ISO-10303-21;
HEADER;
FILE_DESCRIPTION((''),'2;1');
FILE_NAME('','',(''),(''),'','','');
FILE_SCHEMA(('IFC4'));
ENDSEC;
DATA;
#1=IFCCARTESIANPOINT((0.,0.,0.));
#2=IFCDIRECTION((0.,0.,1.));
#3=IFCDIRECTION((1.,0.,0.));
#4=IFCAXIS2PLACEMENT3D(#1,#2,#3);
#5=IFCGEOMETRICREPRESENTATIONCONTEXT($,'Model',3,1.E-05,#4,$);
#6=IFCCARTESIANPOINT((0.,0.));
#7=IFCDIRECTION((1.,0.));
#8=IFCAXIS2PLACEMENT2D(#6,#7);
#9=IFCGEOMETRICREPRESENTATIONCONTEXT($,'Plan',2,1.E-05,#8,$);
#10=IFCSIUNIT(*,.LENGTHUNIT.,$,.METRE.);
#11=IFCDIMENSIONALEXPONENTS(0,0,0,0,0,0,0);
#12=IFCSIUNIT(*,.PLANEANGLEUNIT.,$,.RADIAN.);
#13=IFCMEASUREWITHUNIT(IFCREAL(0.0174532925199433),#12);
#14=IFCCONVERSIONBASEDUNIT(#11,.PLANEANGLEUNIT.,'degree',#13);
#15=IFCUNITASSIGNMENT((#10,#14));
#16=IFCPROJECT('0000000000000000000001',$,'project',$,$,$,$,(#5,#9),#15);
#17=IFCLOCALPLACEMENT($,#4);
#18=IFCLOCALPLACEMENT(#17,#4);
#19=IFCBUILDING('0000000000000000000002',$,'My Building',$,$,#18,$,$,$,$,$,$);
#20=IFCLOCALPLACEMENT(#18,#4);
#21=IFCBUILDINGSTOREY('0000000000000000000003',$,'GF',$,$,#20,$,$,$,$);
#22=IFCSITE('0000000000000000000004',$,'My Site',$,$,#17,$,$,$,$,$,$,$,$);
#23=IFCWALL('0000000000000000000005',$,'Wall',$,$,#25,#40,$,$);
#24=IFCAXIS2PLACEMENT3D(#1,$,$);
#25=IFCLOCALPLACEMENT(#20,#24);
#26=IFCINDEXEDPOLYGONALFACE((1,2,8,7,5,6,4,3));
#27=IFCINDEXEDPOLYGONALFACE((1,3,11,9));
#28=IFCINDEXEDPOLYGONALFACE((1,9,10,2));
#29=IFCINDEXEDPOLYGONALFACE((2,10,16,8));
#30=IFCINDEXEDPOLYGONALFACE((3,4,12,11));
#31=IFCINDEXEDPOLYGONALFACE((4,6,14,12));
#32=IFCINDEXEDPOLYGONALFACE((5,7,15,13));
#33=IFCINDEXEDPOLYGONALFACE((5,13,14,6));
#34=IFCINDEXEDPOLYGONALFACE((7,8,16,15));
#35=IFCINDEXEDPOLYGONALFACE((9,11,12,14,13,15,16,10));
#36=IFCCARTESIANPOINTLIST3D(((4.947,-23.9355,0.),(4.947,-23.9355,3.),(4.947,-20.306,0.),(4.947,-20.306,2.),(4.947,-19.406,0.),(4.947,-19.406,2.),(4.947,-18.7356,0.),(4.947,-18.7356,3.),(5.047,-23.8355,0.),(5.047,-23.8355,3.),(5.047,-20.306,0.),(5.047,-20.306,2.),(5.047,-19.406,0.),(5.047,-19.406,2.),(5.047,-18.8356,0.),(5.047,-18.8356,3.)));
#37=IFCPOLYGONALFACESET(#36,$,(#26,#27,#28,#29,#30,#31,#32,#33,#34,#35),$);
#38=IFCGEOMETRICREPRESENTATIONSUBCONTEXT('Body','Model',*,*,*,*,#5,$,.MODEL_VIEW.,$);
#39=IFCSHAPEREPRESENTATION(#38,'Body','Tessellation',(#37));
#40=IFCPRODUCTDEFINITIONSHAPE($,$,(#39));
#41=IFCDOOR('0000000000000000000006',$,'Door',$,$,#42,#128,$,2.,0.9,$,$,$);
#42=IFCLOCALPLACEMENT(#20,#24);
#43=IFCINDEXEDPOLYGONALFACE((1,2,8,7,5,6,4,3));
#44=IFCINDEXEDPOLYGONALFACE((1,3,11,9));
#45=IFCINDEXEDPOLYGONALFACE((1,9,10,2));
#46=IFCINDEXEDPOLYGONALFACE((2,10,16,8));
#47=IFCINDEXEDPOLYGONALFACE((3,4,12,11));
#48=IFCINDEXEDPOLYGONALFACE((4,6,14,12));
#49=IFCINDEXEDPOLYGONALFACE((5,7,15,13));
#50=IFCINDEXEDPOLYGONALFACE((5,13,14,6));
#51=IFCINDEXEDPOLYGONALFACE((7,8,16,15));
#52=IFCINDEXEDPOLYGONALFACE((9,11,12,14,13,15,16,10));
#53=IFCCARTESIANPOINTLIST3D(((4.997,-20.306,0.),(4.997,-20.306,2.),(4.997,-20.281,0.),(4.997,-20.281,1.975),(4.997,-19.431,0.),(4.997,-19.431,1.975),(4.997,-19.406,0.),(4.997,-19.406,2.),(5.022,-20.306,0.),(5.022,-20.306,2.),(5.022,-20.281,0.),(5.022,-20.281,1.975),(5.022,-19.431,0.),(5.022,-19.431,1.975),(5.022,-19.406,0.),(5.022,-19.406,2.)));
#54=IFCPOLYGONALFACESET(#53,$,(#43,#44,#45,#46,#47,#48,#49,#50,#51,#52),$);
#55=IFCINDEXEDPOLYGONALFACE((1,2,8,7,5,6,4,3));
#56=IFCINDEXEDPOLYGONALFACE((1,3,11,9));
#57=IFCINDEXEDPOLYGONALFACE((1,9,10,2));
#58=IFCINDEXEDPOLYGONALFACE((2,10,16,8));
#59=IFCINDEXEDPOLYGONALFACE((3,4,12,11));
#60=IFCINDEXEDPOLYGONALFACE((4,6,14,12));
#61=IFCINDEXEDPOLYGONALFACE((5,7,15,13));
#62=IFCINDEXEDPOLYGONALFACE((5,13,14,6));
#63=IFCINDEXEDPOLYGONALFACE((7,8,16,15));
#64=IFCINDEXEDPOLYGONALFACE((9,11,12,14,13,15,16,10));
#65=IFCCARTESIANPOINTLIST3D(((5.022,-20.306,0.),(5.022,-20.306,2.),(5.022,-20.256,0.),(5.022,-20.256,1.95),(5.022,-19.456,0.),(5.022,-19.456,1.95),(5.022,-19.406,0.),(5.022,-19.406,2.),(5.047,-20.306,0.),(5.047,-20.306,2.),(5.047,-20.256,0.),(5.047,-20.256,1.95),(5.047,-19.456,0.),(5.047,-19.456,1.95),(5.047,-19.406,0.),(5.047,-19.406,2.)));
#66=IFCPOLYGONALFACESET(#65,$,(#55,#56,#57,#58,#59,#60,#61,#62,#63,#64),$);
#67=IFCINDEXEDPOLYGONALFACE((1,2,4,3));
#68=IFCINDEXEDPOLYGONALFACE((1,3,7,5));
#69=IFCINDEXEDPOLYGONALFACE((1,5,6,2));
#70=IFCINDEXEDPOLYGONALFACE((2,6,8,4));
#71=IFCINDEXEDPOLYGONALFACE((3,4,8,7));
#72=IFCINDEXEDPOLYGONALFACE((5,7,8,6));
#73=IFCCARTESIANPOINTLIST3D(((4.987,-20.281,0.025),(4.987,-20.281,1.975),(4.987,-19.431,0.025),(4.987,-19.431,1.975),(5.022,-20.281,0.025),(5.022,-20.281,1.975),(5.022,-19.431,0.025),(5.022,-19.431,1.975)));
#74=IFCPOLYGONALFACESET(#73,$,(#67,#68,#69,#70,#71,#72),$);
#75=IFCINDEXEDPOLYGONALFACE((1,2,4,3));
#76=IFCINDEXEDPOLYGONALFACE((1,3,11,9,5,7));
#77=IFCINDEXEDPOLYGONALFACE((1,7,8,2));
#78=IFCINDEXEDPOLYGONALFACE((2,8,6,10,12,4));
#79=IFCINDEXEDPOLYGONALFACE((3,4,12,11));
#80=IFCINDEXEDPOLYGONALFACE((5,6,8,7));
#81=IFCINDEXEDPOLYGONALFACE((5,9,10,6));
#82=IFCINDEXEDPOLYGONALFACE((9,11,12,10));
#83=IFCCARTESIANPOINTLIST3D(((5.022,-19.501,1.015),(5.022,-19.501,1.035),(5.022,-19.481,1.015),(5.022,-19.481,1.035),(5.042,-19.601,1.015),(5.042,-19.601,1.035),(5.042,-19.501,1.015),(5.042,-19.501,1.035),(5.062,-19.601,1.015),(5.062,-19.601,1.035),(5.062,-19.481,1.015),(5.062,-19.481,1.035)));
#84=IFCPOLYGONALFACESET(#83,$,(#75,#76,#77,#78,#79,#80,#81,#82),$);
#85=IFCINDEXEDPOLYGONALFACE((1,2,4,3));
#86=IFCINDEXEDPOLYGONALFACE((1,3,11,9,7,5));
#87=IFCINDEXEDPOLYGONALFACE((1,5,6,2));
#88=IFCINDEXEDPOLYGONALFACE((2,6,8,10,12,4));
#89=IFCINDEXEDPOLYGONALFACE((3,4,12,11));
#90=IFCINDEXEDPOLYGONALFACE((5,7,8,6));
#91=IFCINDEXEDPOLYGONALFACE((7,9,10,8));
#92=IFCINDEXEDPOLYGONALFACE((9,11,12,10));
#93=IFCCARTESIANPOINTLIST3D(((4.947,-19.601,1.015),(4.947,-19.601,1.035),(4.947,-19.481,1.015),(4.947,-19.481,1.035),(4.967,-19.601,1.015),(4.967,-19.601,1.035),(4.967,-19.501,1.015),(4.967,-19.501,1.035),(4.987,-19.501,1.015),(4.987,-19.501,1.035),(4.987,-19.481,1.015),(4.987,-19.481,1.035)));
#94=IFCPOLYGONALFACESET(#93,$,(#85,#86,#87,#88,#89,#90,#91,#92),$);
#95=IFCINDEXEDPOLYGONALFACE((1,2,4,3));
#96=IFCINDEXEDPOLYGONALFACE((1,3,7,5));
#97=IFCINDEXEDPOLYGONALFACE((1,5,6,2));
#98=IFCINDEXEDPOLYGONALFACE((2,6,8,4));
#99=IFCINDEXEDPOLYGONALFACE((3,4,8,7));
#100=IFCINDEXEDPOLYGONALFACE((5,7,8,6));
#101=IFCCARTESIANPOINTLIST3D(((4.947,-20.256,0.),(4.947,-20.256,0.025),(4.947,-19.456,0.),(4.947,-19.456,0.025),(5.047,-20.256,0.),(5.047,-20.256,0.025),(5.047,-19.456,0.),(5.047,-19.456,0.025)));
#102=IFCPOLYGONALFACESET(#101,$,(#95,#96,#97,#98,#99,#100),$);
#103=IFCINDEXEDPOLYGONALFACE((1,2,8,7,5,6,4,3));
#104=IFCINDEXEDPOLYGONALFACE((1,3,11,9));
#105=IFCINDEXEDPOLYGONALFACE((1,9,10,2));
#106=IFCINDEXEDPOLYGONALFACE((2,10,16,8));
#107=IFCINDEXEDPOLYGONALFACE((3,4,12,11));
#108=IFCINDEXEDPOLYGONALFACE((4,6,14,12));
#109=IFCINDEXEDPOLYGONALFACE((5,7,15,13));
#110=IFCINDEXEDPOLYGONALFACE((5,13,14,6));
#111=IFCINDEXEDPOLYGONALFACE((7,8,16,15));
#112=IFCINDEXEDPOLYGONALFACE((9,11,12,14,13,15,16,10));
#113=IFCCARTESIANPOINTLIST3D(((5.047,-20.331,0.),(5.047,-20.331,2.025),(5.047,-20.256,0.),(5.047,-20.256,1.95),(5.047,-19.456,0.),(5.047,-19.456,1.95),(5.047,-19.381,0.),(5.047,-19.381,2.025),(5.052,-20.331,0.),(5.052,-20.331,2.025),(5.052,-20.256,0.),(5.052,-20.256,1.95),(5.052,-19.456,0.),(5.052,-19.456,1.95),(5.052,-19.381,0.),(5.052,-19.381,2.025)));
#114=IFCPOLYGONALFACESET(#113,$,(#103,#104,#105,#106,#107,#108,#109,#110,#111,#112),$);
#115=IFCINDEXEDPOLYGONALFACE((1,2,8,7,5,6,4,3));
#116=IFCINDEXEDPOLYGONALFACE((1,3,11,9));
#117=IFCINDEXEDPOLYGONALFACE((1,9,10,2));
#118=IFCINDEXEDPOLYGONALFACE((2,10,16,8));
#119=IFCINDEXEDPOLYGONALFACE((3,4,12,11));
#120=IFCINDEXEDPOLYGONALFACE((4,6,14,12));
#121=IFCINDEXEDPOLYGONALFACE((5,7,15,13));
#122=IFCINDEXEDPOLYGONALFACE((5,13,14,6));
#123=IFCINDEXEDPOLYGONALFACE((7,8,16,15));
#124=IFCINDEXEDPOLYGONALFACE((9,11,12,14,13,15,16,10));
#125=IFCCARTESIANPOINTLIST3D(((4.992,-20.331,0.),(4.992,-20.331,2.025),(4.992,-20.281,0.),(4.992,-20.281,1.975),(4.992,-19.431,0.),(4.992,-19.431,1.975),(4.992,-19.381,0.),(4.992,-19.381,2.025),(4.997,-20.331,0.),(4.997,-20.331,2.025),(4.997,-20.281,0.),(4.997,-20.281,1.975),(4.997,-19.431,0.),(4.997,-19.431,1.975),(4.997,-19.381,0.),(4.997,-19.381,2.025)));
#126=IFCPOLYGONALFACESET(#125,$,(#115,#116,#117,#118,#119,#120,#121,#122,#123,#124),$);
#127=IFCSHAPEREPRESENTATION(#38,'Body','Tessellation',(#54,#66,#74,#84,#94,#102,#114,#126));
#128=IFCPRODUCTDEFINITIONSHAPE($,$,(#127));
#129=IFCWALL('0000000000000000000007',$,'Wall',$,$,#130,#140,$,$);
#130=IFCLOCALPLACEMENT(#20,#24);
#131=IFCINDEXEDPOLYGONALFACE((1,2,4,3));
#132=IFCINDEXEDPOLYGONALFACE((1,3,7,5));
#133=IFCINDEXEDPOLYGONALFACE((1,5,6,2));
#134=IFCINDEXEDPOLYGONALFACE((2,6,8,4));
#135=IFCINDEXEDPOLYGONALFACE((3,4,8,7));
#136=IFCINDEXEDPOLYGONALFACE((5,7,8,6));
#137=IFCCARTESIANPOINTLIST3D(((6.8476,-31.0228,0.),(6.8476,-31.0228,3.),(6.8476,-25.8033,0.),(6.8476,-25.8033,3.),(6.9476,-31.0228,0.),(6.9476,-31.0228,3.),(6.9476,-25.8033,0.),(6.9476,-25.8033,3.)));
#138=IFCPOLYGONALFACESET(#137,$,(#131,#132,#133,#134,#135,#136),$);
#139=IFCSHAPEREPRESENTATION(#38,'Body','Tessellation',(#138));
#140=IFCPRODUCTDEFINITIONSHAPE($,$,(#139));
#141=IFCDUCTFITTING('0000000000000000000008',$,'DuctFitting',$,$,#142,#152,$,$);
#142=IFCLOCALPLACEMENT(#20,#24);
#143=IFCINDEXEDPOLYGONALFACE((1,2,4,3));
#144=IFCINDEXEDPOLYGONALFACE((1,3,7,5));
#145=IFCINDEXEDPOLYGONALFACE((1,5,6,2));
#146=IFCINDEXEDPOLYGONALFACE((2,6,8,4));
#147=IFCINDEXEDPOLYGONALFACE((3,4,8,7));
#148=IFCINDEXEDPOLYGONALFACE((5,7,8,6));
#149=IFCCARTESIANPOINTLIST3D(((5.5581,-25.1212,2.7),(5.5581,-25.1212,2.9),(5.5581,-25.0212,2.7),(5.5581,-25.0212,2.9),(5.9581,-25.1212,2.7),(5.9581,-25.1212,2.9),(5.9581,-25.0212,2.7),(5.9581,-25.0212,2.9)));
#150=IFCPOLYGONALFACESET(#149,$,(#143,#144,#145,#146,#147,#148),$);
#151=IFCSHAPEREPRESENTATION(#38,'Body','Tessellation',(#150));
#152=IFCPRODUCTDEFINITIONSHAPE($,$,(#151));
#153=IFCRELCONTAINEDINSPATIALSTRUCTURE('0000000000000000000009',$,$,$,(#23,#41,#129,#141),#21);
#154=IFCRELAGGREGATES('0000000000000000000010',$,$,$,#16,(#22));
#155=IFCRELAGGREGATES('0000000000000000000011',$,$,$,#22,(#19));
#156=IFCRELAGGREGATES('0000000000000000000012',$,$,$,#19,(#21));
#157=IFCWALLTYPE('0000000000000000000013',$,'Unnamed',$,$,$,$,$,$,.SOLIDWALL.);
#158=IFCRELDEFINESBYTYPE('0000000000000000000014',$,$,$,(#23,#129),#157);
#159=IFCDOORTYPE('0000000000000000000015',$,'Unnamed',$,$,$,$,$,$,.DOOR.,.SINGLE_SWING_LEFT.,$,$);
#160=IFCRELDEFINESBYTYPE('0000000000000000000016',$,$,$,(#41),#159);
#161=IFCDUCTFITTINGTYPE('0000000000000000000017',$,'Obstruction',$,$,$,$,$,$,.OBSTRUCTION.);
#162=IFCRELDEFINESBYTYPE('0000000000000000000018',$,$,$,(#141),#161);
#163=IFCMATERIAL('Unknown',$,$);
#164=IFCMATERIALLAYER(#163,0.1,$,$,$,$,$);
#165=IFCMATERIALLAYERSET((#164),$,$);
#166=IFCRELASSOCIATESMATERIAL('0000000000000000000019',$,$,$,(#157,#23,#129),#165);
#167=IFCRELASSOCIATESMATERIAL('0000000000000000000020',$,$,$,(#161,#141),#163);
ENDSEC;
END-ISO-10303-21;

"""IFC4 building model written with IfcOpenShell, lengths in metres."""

from ifc_helpers import new_model, entity, si_unit, converted_unit, frame, origin_with_axes, origin_2d_with_axis, place, context, subcontext, project, spatial, line, indexed_curve, rectangle, outline, extrude, shape, source, transform, mapped, material, layer, layer_set, layer_usage, material_profile, profile_set, profile_usage, type_object, type_shapes, element, fill, save


model = new_model("IFC4")

# Units and contexts
model_context = context("Model", 3, precision=1e-05, world=origin_with_axes())
plan_context = context("Plan", 2, precision=1e-05, world=origin_2d_with_axis())
body_context_1 = subcontext(model_context, "Body", "Model", "MODEL_VIEW")
body_context_2 = subcontext(plan_context, "Body", "Plan", "PLAN_VIEW")
ifc_project = project(units=[si_unit("LENGTHUNIT", "METRE"), converted_unit("PLANEANGLEUNIT", "degree", entity("IfcReal", 0.0174532925199433), si_unit("PLANEANGLEUNIT", "RADIAN"), dimensions=[0, 0, 0, 0, 0, 0, 0])], contexts=[model_context, plan_context])

# Site, building, storey
site_placement = place(None, origin_with_axes())
site = spatial("IfcSite", under=ifc_project, at=site_placement, Name="My Site")
building_placement = place(site_placement, origin_with_axes())
building = spatial("IfcBuilding", under=site, at=building_placement, Name="My Building")
storey_placement = place(building_placement, origin_with_axes())
storey = spatial("IfcBuildingStorey", under=building, at=storey_placement, Name="GF")

# Shared definitions
ifc_material = material(Name="Unknown")

# Shared definitions
ifc_layer_1 = layer(ifc_material, 0.1)
ifc_layer_set_1 = layer_set([ifc_layer_1])
wall_type = type_object("IfcWallType", Name="Unnamed", PredefinedType="SOLIDWALL", material=ifc_layer_set_1)

# Shared definitions
shared_shape_1 = source(origin_with_axes(), body_context_1, "Body", "SweptSolid", [
    extrude(outline(indexed_curve([(0.0, 0.0), (0.9, 0.0), (0.9, 2.0), (0.0, 2.0)], segments=[line(1, 2, 3, 4, 1)])), frame((0.0, -0.6, 0.0), z_axis=(0.0, -1.0, 0.0), x_axis=(1.0, 0.0, 0.0)), (0.0, 0.0, -1.0), 1.2),
])
door_type = type_object("IfcDoorType", Name="Unnamed", OperationType="SINGLE_SWING_LEFT", PredefinedType="DOOR")
shared_shape_2 = source(origin_with_axes(), body_context_1, "Body", "SweptSolid", [
    extrude(outline(indexed_curve([(0.0, 0.0), (0.0, 2.0), (0.9, 2.0), (0.9, 0.0), (0.875, 0.0), (0.875, 1.975), (0.025, 1.975), (0.025, 0.0)], segments=[line(1, 2, 3, 4, 5, 6, 7, 8, 1)])), frame((0.0, 0.025, 0.0), z_axis=(0.0, -1.0, 0.0), x_axis=(1.0, 0.0, 0.0)), (0.0, 0.0, -1.0), 0.025),
    extrude(outline(indexed_curve([(0.0, 0.0), (0.0, 2.0), (0.9, 2.0), (0.9, 0.0), (0.85, 0.0), (0.85, 1.95), (0.05, 1.95), (0.05, 0.0)], segments=[line(1, 2, 3, 4, 5, 6, 7, 8, 1)])), frame((0.0, 0.0, 0.0), z_axis=(0.0, -1.0, 0.0), x_axis=(1.0, 0.0, 0.0)), (0.0, 0.0, -1.0), 0.025),
    extrude(outline(indexed_curve([(0.0, 0.0), (0.85, 0.0), (0.85, 0.035), (0.0, 0.035)], segments=[line(1, 2, 3, 4, 1)])), frame((0.025, 0.025, 0.025), z_axis=(0.0, 0.0, 1.0), x_axis=(1.0, 0.0, 0.0)), (0.0, 0.0, 1.0), 1.95),
    extrude(outline(indexed_curve([(0.0, 0.0), (0.0, -0.04), (-0.12, -0.04), (-0.12, -0.02), (-0.02, -0.02), (-0.02, 0.0)], segments=[line(1, 2, 3, 4, 5, 6, 1)])), frame((0.825, 0.025, 1.015), z_axis=(0.0, 0.0, 1.0), x_axis=(1.0, 0.0, 0.0)), (0.0, 0.0, 1.0), 0.02),
    extrude(outline(indexed_curve([(0.0, 0.0), (0.0, 0.04), (-0.12, 0.04), (-0.12, 0.02), (-0.02, 0.02), (-0.02, 0.0)], segments=[line(1, 2, 3, 4, 5, 6, 1)])), frame((0.825, 0.06, 1.015), z_axis=(0.0, 0.0, 1.0), x_axis=(1.0, 0.0, 0.0)), (0.0, 0.0, 1.0), 0.02),
    extrude(outline(indexed_curve([(0.0, 0.0), (0.8, 0.0), (0.8, 0.1), (0.0, 0.1)], segments=[line(1, 2, 3, 4, 1)])), frame((0.05, 0.0, 0.0), z_axis=(0.0, 0.0, 1.0), x_axis=(1.0, 0.0, 0.0)), (0.0, 0.0, 1.0), 0.025),
    extrude(outline(indexed_curve([(0.0, 0.0), (0.0, 2.025), (0.95, 2.025), (0.95, 0.0), (0.875, 0.0), (0.875, 1.95), (0.075, 1.95), (0.075, 0.0)], segments=[line(1, 2, 3, 4, 5, 6, 7, 8, 1)])), frame((-0.025, -0.005, 0.0), z_axis=(0.0, -1.0, 0.0), x_axis=(1.0, 0.0, 0.0)), (0.0, 0.0, -1.0), 0.005),
    extrude(outline(indexed_curve([(0.0, 0.0), (0.0, 2.025), (0.95, 2.025), (0.95, 0.0), (0.9, 0.0), (0.9, 1.975), (0.05, 1.975), (0.05, 0.0)], segments=[line(1, 2, 3, 4, 5, 6, 7, 8, 1)])), frame((-0.025, 0.05, 0.0), z_axis=(0.0, -1.0, 0.0), x_axis=(1.0, 0.0, 0.0)), (0.0, 0.0, -1.0), 0.005),
])
shared_shape_3 = source(origin_with_axes(), body_context_2, "Body", "Curve2D", [
    entity("IfcIndexedPolyCurve", entity("IfcCartesianPointList2D", [[0.0, 0.0], [0.0, 0.05], [0.025, 0.05], [0.025, 0.025], [0.05, 0.025], [0.05, 0.0]]), [entity("IfcLineIndex", [1, 2, 3, 4, 5, 6, 1])]),
    entity("IfcIndexedPolyCurve", entity("IfcCartesianPointList2D", [[0.9, 0.0], [0.9, 0.05], [0.875, 0.05], [0.875, 0.025], [0.85, 0.025], [0.85, 0.0]]), [entity("IfcLineIndex", [1, 2, 3, 4, 5, 6, 1])]),
    entity("IfcTrimmedCurve", entity("IfcEllipse", entity("IfcAxis2Placement2D", entity("IfcCartesianPoint", [0.06, 0.05]), entity("IfcDirection", [1.0, 0.0])), 0.815, 0.85), [entity("IfcCartesianPoint", [0.875, 0.05])], [entity("IfcCartesianPoint", [0.06, 0.9])], True, "CARTESIAN"),
    entity("IfcIndexedPolyCurve", entity("IfcCartesianPointList2D", [[0.025, 0.05], [0.06, 0.05], [0.06, 0.9], [0.025, 0.9]]), [entity("IfcLineIndex", [1, 2, 3, 4, 1])]),
])
type_shapes(door_type, [shared_shape_2, shared_shape_3])

# Wall, opening, door
ifc_layer_usage_1 = layer_usage(ifc_layer_set_1, "AXIS2", "POSITIVE", 0.0)
wall_1_placement = place(storey_placement, frame((5.047, -23.8355, 0.0), z_axis=(0.0, 0.0, 1.0), x_axis=(0.0, 1.0, 0.0)))
wall_1 = element("IfcWall", 1, at=wall_1_placement, inside=storey, type_object=wall_type, material=ifc_layer_usage_1, Name="Wall", context=body_context_1, shape_type="SweptSolid", body=[
    extrude(outline(indexed_curve([(0.0, 0.0), (-0.1, 0.1), (5.1, 0.1), (5.0, 0.0)], segments=[line(1, 2, 3, 4, 1)])), origin_with_axes(), (0.0, 0.0, 1.0), 3.0),
])
opening_1_placement = place(wall_1_placement, frame((3.5295, 0.0, 0.0), z_axis=(0.0, 0.0, 1.0), x_axis=(1.0, 0.0, 0.0)))
opening_1 = element("IfcOpeningElement", 2, at=opening_1_placement, cuts=wall_1, PredefinedType="OPENING", context=body_context_1, shape_type="MappedRepresentation", body=[
    mapped(shared_shape_1, transform((0.0, 0.0, 0.0), x_axis=(1.0, 0.0, 0.0), y_axis=(0.0, 1.0, 0.0), z_axis=(0.0, 0.0, 1.0), scale=1.0)),
])
door_1_placement = place(opening_1_placement, frame((0.0, 0.0, 0.0), z_axis=(0.0, 0.0, 1.0), x_axis=(1.0, 0.0, 0.0)))
door_1 = element("IfcDoor", 3, at=door_1_placement, inside=storey, type_object=door_type, Name="Door", OverallHeight=2.0, OverallWidth=0.9, shapes=[
    shape(body_context_1, "Body", "MappedRepresentation", [mapped(shared_shape_2, transform((0.0, 0.0, 0.0), x_axis=(1.0, 0.0, 0.0), y_axis=(0.0, 1.0, 0.0), z_axis=(0.0, 0.0, 1.0), scale=1.0))]),
    shape(body_context_2, "Body", "MappedRepresentation", [mapped(shared_shape_3, transform((0.0, 0.0, 0.0), x_axis=(1.0, 0.0, 0.0), y_axis=(0.0, 1.0, 0.0), z_axis=(0.0, 0.0, 1.0), scale=1.0))]),
])
fill(opening_1, door_1)

# Wall
ifc_layer_usage_2 = layer_usage(ifc_layer_set_1, "AXIS2", "POSITIVE", 0.0)
wall_2_placement = place(storey_placement, frame((6.8476, -25.8033, 0.0), z_axis=(0.0, 0.0, 1.0), x_axis=(0.0, -1.0, 0.0)))
element("IfcWall", 4, at=wall_2_placement, inside=storey, type_object=wall_type, material=ifc_layer_usage_2, Name="Wall", context=body_context_1, shape_type="SweptSolid", body=[
    extrude(outline(indexed_curve([(0.0, 0.0), (0.0, 0.1), (5.2195, 0.1), (5.2195, 0.0)], segments=[line(1, 2, 3, 4, 1)])), origin_with_axes(), (0.0, 0.0, 1.0), 3.0),
])

# Duct fitting
ifc_material_profile = material_profile(ifc_material, rectangle(XDim=0.4, YDim=0.2))
ifc_profile_set = profile_set([ifc_material_profile])
ifc_profile_usage = profile_usage(ifc_profile_set, cardinal=5)
duct_fitting_type = type_object("IfcDuctFittingType", Name="Obstruction", PredefinedType="OBSTRUCTION", material=ifc_profile_set)
duct_fitting_placement = place(storey_placement, frame((5.7581, -25.1212, 2.8), z_axis=(0.0, 1.0, 0.0), x_axis=(-1.0, 0.0, 0.0)))
element("IfcDuctFitting", 5, at=duct_fitting_placement, inside=storey, type_object=duct_fitting_type, material=ifc_profile_usage, Name="DuctFitting", context=body_context_1, shape_type="SweptSolid", body=[
    extrude(rectangle(XDim=0.4, YDim=0.2), origin_with_axes(), (0.0, 0.0, 1.0), 0.1),
])

save(model, "model.ifc")
